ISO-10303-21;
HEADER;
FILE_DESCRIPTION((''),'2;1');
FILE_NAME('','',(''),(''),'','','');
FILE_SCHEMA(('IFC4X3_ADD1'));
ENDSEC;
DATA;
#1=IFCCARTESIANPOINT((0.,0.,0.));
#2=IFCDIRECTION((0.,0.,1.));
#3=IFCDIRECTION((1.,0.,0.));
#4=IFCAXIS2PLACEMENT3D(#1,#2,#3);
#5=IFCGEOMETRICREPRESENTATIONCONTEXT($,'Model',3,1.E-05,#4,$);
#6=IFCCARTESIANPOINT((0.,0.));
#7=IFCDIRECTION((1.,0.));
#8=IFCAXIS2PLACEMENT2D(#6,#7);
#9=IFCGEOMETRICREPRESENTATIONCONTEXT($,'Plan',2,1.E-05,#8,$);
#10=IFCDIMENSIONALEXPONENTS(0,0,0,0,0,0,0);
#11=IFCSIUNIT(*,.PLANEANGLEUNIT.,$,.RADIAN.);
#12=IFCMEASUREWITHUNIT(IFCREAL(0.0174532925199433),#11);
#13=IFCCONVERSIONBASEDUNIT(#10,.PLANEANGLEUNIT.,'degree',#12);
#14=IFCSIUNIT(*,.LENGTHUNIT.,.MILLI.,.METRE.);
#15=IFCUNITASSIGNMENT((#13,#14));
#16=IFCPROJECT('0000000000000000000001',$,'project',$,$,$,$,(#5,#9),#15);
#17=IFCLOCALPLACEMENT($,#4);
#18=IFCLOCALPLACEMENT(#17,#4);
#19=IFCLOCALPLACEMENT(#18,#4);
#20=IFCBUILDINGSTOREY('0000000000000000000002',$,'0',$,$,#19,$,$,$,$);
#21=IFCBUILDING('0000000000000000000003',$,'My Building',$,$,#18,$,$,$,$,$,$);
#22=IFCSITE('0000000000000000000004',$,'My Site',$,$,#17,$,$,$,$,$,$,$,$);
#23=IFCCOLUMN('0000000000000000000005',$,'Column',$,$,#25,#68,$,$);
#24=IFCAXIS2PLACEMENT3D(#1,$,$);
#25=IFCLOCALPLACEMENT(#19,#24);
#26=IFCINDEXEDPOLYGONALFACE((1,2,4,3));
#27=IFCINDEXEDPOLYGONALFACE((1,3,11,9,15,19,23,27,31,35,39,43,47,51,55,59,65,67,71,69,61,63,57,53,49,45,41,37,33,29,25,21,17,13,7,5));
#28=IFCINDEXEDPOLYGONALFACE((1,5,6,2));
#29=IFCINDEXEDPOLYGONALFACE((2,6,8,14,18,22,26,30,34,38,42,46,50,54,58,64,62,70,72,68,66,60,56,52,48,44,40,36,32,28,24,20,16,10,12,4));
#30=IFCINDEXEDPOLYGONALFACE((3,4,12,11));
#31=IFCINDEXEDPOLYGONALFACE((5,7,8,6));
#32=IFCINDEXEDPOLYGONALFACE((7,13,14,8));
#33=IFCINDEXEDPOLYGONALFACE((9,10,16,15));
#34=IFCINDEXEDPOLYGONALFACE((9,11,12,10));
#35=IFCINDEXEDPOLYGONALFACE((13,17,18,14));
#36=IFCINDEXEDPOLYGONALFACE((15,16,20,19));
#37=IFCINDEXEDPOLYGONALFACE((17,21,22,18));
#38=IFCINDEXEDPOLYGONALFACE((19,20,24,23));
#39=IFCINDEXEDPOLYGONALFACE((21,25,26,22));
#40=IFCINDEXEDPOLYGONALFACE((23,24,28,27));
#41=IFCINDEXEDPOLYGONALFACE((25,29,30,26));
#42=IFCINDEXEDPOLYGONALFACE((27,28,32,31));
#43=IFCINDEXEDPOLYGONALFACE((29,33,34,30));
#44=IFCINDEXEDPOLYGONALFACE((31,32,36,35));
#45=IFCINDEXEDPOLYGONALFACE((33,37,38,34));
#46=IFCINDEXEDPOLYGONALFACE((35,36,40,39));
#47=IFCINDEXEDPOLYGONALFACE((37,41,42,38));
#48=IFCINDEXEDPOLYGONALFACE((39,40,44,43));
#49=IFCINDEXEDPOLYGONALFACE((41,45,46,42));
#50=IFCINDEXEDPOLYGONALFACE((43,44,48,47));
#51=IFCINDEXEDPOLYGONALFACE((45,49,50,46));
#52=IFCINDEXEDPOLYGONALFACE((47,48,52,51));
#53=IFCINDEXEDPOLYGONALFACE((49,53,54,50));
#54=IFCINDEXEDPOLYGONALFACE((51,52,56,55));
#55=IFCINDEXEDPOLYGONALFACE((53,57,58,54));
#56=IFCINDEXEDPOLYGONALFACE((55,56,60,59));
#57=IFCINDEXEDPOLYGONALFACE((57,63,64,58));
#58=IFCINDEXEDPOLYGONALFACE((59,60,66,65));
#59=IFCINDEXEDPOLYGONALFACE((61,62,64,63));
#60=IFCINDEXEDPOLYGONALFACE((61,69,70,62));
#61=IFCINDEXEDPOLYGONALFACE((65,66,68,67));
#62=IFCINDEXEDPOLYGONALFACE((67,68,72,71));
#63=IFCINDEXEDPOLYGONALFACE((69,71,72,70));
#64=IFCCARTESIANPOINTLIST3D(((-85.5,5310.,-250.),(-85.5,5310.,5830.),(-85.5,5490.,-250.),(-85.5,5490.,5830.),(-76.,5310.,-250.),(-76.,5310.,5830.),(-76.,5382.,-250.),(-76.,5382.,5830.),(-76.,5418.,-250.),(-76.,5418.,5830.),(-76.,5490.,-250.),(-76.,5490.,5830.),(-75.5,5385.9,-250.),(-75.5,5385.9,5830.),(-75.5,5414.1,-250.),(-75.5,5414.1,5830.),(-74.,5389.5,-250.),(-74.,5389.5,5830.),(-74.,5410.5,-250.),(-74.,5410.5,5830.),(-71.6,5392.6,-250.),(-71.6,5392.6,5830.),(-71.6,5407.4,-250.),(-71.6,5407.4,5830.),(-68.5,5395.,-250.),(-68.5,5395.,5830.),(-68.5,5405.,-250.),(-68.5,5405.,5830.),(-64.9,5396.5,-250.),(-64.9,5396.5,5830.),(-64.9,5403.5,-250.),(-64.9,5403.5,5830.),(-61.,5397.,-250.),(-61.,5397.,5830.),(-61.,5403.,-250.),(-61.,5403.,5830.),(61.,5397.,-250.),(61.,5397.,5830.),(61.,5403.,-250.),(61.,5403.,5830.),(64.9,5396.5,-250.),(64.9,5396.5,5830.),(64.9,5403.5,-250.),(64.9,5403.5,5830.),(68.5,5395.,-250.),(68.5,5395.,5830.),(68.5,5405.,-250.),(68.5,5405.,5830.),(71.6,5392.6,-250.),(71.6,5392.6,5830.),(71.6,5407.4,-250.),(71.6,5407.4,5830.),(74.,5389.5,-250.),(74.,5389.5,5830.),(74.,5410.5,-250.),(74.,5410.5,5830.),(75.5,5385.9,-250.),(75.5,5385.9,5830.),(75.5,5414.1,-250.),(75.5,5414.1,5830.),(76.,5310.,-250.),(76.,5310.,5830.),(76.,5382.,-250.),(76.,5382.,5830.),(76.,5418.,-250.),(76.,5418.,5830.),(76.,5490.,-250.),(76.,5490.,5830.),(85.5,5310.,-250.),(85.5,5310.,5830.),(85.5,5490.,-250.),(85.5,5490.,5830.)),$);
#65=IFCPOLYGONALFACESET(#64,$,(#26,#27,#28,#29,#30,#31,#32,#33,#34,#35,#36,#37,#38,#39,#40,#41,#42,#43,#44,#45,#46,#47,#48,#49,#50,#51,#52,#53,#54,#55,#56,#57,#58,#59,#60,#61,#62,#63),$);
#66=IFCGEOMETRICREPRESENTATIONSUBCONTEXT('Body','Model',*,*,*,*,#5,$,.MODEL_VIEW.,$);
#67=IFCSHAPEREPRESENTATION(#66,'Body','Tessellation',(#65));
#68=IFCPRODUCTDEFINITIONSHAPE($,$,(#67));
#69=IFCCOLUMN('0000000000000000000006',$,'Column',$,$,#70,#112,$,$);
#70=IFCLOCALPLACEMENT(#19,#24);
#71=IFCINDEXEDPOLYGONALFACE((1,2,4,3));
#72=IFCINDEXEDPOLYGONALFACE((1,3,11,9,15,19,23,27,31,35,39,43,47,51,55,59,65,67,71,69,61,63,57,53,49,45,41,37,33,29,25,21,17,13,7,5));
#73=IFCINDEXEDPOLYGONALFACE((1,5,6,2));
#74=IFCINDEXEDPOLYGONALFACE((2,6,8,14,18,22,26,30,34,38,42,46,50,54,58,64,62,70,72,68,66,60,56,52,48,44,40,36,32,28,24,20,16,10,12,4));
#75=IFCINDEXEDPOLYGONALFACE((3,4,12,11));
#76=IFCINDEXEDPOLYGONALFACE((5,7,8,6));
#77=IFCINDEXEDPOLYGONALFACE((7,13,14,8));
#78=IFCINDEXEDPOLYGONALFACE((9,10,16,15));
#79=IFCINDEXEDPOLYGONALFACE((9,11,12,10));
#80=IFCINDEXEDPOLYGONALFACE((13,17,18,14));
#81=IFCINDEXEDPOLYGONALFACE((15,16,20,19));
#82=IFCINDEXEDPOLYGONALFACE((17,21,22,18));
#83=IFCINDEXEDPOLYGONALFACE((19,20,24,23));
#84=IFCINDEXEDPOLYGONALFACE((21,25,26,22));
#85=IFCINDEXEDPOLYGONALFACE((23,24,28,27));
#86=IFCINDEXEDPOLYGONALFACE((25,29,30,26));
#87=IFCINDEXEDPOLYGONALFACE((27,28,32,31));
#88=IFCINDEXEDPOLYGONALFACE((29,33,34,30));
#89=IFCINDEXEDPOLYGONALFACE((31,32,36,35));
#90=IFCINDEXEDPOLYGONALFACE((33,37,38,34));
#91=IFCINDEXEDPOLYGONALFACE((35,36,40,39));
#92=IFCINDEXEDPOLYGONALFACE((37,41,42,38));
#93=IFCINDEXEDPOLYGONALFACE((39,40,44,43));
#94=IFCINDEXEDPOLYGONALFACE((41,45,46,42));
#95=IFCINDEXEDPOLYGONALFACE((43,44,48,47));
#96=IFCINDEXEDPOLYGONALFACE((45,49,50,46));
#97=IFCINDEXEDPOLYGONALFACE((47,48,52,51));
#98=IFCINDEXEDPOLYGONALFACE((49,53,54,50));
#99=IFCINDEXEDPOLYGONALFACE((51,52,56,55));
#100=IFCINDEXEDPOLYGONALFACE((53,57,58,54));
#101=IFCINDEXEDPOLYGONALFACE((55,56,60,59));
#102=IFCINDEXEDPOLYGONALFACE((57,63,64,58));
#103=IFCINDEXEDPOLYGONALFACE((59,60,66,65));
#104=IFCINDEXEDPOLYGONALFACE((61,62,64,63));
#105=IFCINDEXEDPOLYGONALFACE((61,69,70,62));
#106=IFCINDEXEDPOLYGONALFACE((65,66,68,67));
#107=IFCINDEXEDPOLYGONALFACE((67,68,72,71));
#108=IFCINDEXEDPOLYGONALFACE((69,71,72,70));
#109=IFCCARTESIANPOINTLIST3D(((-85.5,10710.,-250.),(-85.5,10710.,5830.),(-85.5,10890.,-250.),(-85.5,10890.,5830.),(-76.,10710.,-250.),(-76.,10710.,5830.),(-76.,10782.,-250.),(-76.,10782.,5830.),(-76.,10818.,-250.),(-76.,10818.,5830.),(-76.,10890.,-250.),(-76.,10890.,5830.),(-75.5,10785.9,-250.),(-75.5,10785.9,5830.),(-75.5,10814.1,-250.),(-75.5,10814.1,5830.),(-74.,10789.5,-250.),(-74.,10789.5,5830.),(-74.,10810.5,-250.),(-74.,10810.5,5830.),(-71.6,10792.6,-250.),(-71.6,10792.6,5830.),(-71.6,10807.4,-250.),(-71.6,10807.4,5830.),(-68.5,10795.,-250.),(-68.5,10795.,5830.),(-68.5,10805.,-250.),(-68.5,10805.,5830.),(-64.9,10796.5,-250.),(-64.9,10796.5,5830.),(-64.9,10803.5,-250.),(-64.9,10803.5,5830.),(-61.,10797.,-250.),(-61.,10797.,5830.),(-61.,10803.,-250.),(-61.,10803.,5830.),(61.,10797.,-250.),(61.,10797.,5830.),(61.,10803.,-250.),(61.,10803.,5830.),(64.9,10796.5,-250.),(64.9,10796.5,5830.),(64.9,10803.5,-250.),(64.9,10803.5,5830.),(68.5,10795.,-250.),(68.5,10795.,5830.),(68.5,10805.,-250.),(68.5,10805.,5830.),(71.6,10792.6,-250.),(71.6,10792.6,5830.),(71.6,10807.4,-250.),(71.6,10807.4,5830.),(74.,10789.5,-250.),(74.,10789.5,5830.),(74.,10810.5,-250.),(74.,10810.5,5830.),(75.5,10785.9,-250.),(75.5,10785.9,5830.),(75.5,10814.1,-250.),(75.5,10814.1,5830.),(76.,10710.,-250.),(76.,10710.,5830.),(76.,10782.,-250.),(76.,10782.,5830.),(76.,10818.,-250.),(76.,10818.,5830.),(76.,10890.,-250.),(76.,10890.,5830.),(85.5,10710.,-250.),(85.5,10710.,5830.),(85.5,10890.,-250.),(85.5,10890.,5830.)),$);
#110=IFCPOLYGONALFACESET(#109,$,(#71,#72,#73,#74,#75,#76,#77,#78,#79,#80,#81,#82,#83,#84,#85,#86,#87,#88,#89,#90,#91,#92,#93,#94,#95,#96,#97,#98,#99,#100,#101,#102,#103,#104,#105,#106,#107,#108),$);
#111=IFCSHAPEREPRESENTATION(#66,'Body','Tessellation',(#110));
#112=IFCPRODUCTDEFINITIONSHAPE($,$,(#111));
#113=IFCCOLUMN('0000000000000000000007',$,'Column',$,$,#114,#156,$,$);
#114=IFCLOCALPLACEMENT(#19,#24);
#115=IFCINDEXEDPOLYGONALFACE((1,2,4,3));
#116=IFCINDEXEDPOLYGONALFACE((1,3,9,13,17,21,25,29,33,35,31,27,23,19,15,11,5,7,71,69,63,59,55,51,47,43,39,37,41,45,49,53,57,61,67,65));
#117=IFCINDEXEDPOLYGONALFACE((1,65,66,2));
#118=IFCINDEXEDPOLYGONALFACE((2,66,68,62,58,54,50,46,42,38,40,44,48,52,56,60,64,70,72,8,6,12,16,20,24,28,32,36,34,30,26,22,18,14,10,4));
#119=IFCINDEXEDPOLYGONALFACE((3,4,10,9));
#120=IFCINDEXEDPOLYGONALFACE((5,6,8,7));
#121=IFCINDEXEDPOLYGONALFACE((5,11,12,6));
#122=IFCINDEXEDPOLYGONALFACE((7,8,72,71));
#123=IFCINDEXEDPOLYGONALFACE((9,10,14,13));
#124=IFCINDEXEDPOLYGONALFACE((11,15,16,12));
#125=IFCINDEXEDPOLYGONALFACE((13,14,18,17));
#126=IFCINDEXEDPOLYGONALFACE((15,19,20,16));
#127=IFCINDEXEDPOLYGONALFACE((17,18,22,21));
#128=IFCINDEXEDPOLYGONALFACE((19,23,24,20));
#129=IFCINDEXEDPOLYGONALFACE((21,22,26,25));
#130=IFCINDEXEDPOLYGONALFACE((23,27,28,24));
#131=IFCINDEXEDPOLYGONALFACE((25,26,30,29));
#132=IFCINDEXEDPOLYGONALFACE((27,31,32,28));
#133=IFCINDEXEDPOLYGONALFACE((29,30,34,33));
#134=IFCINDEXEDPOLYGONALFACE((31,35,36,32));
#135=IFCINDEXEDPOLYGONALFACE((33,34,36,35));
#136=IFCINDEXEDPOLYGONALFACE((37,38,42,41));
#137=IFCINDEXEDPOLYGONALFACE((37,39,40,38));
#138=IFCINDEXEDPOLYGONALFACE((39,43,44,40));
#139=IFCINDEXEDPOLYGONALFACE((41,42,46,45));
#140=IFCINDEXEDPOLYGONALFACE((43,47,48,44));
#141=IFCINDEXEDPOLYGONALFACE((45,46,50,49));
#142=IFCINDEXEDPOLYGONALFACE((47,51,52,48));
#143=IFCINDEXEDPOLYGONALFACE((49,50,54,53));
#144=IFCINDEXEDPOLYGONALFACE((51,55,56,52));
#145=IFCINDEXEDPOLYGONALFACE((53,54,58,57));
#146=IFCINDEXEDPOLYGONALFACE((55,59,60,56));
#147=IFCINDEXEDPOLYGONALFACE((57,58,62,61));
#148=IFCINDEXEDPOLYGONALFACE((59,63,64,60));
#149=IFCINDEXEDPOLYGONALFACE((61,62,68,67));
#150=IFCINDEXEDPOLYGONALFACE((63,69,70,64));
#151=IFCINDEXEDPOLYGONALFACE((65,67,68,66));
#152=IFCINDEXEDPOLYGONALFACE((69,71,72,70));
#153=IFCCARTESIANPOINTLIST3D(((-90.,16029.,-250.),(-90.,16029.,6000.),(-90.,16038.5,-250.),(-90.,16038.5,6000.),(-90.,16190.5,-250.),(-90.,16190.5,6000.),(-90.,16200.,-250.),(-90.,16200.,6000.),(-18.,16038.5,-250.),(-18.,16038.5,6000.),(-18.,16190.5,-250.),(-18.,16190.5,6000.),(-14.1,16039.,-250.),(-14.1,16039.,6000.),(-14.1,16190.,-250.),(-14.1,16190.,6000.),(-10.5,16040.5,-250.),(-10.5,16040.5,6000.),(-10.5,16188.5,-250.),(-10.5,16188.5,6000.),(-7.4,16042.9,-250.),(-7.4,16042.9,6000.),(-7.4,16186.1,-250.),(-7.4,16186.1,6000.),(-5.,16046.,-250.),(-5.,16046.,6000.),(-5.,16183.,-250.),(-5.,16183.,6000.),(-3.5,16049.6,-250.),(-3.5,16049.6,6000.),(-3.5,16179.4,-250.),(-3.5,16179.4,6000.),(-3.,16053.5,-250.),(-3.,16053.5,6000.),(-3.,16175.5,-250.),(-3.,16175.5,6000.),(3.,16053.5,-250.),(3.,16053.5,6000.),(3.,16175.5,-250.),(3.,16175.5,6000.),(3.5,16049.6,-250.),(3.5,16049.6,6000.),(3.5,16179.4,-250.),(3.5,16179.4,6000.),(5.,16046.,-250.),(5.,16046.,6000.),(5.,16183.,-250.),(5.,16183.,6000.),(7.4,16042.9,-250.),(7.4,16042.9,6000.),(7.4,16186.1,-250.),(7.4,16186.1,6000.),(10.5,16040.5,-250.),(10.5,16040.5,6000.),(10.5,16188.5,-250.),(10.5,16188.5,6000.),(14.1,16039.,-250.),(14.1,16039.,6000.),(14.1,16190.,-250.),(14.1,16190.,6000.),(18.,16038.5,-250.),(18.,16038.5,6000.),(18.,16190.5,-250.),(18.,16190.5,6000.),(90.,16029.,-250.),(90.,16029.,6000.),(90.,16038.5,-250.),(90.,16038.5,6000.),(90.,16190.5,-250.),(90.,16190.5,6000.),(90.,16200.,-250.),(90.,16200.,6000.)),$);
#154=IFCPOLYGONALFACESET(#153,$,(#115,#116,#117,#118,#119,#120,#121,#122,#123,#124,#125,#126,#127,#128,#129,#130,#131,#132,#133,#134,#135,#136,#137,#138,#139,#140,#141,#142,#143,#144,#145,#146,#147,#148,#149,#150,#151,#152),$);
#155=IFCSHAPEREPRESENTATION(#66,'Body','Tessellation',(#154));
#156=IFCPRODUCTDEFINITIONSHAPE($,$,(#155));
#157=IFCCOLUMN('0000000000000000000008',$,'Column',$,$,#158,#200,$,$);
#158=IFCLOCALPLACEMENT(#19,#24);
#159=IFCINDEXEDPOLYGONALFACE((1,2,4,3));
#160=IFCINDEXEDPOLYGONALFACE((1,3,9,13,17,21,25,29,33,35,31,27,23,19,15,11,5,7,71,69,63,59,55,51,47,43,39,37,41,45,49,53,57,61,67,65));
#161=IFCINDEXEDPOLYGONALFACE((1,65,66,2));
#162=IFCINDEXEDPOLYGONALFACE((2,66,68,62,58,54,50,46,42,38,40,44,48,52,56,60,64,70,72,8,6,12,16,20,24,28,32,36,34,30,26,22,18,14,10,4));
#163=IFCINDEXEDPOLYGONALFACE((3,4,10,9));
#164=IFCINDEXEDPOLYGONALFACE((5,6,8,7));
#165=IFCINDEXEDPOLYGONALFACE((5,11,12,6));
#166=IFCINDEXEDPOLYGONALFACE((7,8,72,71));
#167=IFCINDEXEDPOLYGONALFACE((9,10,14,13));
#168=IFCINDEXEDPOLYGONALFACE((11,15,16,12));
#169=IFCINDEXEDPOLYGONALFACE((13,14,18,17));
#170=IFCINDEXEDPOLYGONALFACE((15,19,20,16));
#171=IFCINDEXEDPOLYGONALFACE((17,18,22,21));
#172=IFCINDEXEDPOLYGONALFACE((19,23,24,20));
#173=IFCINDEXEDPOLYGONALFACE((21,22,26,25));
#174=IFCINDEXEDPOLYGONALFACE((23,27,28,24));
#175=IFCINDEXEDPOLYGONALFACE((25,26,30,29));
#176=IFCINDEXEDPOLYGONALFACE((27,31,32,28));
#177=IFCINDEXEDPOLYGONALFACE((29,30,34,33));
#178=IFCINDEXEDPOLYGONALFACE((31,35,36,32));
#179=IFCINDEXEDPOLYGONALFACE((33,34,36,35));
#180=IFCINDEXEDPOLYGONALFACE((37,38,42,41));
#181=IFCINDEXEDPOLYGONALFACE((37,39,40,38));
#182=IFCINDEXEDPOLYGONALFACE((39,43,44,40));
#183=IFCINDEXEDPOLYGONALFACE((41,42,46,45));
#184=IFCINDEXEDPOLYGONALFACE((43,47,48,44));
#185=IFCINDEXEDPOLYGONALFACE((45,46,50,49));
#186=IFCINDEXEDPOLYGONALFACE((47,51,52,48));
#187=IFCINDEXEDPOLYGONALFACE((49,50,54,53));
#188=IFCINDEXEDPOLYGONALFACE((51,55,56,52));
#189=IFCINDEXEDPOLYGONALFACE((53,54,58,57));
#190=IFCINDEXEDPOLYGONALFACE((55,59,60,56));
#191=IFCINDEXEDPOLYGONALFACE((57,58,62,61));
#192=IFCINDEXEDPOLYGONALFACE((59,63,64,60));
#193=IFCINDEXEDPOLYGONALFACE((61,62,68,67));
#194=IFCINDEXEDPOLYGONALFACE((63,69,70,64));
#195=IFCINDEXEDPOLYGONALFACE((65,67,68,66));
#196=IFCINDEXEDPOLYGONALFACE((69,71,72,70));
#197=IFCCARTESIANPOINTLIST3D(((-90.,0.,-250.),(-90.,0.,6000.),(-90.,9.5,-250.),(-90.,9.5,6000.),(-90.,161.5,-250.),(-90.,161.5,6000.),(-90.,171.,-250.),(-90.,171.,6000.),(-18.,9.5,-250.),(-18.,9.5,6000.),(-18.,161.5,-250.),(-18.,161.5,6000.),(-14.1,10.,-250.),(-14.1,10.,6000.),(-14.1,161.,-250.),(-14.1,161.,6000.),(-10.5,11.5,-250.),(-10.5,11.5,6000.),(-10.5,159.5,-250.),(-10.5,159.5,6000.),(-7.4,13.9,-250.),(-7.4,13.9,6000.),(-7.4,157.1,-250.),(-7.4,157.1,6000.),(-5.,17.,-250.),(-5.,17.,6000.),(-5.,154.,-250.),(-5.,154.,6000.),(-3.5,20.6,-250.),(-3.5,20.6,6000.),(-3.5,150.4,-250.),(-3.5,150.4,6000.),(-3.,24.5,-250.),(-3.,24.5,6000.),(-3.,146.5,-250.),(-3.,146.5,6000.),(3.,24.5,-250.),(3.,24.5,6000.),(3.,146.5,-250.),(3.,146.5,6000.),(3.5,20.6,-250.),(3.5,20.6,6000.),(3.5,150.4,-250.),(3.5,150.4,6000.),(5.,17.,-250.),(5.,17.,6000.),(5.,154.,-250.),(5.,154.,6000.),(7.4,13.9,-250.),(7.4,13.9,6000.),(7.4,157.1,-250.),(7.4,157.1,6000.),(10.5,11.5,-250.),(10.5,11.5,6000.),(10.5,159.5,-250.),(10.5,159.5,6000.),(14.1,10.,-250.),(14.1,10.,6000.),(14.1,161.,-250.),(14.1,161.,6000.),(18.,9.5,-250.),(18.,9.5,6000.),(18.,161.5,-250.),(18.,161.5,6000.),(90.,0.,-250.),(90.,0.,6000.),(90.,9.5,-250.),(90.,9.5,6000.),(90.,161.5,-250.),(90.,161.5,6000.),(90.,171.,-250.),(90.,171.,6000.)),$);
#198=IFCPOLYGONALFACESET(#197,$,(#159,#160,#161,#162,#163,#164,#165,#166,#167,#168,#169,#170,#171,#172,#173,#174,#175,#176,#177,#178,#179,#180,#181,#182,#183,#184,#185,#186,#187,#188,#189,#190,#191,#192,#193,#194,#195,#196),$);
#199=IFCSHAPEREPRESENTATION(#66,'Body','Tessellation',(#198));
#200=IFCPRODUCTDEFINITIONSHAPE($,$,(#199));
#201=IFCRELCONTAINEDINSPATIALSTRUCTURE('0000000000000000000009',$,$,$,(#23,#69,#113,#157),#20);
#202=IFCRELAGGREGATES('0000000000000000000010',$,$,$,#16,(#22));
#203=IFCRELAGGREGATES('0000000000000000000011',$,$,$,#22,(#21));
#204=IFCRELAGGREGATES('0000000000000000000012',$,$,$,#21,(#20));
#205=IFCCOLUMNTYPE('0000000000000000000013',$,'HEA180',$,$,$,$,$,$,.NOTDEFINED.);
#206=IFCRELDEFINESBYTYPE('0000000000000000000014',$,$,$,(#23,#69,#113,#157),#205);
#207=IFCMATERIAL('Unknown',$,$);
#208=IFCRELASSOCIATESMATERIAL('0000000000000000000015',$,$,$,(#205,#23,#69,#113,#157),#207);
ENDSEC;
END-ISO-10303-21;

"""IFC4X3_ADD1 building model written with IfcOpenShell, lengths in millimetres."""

from ifc_helpers import new_model, entity, si_unit, converted_unit, frame, origin_with_axes, origin_2d_with_axis, place, context, subcontext, project, spatial, i_section, extrude, material, material_profile, profile_set, profile_usage, type_object, element, save


model = new_model("IFC4X3_ADD1")

# Units and contexts
model_context = context("Model", 3, precision=1e-05, world=origin_with_axes())
plan_context = context("Plan", 2, precision=1e-05, world=origin_2d_with_axis())
body_context = subcontext(model_context, "Body", "Model", "MODEL_VIEW")
ifc_project = project(units=[converted_unit("PLANEANGLEUNIT", "degree", entity("IfcReal", 0.0174532925199433), si_unit("PLANEANGLEUNIT", "RADIAN"), dimensions=[0, 0, 0, 0, 0, 0, 0]), si_unit("LENGTHUNIT", "METRE", prefix="MILLI")], contexts=[model_context, plan_context])

# Site, building, storey
site_placement = place(None, origin_with_axes())
site = spatial("IfcSite", under=ifc_project, at=site_placement, Name="My Site")
building_placement = place(site_placement, origin_with_axes())
building = spatial("IfcBuilding", under=site, at=building_placement, Name="My Building")
storey_placement = place(building_placement, origin_with_axes())
storey = spatial("IfcBuildingStorey", under=building, at=storey_placement, Name="0")

# Columns
ifc_material = material(Name="Unknown")
ifc_material_profile_1 = material_profile(ifc_material, i_section(OverallWidth=180.0, OverallDepth=171.0, WebThickness=6.0, FlangeThickness=9.5, FilletRadius=15.0))
ifc_profile_set_1 = profile_set([ifc_material_profile_1])
column_type = type_object("IfcColumnType", Name="HEA180", PredefinedType="NOTDEFINED", material=ifc_profile_set_1)
ifc_profile_usage_1 = profile_usage(ifc_profile_set_1, cardinal=10)
column_1_placement = place(storey_placement, frame((0.0, 5400.0, -250.0), z_axis=(0.0, 0.0, 1.0), x_axis=(0.0, 1.0, 0.0)))
element("IfcColumn", 1, at=column_1_placement, inside=storey, type_object=column_type, material=ifc_profile_usage_1, Name="Column", context=body_context, shape_type="SweptSolid", body=[
    extrude(i_section(OverallWidth=180.0, OverallDepth=171.0, WebThickness=6.0, FlangeThickness=9.5, FilletRadius=15.0), origin_with_axes(), (0.0, 0.0, 1.0), 6080.0),
])
ifc_profile_usage_2 = profile_usage(ifc_profile_set_1, cardinal=10)
column_2_placement = place(storey_placement, frame((0.0, 10800.0, -250.0), z_axis=(0.0, 0.0, 1.0), x_axis=(0.0, 1.0, 0.0)))
element("IfcColumn", 2, at=column_2_placement, inside=storey, type_object=column_type, material=ifc_profile_usage_2, Name="Column", context=body_context, shape_type="SweptSolid", body=[
    extrude(i_section(OverallWidth=180.0, OverallDepth=171.0, WebThickness=6.0, FlangeThickness=9.5, FilletRadius=15.0), origin_with_axes(), (0.0, 0.0, 1.0), 6080.0),
])
ifc_profile_usage_3 = profile_usage(ifc_profile_set_1, cardinal=8)
column_3_placement = place(storey_placement, frame((0.0, 16200.0, -250.0), z_axis=(0.0, 0.0, 1.0), x_axis=(1.0, 0.0, 0.0)))
element("IfcColumn", 3, at=column_3_placement, inside=storey, type_object=column_type, material=ifc_profile_usage_3, Name="Column", context=body_context, shape_type="SweptSolid", body=[
    extrude(i_section(OverallWidth=180.0, OverallDepth=171.0, WebThickness=6.0, FlangeThickness=9.5, FilletRadius=15.0), frame((0.0, -85.5, 0.0), z_axis=(0.0, 0.0, 1.0), x_axis=(1.0, 0.0, 0.0)), (0.0, 0.0, 1.0), 6250.0),
])
ifc_profile_usage_4 = profile_usage(ifc_profile_set_1, cardinal=2)
column_4_placement = place(storey_placement, frame((0.0, 0.0, -250.0), z_axis=(0.0, 0.0, 1.0), x_axis=(1.0, 0.0, 0.0)))
element("IfcColumn", 4, at=column_4_placement, inside=storey, type_object=column_type, material=ifc_profile_usage_4, Name="Column", context=body_context, shape_type="SweptSolid", body=[
    extrude(i_section(OverallWidth=180.0, OverallDepth=171.0, WebThickness=6.0, FlangeThickness=9.5, FilletRadius=15.0), frame((0.0, 85.5, 0.0), z_axis=(0.0, 0.0, 1.0), x_axis=(1.0, 0.0, 0.0)), (0.0, 0.0, 1.0), 6250.0),
])

save(model, "model.ifc")
